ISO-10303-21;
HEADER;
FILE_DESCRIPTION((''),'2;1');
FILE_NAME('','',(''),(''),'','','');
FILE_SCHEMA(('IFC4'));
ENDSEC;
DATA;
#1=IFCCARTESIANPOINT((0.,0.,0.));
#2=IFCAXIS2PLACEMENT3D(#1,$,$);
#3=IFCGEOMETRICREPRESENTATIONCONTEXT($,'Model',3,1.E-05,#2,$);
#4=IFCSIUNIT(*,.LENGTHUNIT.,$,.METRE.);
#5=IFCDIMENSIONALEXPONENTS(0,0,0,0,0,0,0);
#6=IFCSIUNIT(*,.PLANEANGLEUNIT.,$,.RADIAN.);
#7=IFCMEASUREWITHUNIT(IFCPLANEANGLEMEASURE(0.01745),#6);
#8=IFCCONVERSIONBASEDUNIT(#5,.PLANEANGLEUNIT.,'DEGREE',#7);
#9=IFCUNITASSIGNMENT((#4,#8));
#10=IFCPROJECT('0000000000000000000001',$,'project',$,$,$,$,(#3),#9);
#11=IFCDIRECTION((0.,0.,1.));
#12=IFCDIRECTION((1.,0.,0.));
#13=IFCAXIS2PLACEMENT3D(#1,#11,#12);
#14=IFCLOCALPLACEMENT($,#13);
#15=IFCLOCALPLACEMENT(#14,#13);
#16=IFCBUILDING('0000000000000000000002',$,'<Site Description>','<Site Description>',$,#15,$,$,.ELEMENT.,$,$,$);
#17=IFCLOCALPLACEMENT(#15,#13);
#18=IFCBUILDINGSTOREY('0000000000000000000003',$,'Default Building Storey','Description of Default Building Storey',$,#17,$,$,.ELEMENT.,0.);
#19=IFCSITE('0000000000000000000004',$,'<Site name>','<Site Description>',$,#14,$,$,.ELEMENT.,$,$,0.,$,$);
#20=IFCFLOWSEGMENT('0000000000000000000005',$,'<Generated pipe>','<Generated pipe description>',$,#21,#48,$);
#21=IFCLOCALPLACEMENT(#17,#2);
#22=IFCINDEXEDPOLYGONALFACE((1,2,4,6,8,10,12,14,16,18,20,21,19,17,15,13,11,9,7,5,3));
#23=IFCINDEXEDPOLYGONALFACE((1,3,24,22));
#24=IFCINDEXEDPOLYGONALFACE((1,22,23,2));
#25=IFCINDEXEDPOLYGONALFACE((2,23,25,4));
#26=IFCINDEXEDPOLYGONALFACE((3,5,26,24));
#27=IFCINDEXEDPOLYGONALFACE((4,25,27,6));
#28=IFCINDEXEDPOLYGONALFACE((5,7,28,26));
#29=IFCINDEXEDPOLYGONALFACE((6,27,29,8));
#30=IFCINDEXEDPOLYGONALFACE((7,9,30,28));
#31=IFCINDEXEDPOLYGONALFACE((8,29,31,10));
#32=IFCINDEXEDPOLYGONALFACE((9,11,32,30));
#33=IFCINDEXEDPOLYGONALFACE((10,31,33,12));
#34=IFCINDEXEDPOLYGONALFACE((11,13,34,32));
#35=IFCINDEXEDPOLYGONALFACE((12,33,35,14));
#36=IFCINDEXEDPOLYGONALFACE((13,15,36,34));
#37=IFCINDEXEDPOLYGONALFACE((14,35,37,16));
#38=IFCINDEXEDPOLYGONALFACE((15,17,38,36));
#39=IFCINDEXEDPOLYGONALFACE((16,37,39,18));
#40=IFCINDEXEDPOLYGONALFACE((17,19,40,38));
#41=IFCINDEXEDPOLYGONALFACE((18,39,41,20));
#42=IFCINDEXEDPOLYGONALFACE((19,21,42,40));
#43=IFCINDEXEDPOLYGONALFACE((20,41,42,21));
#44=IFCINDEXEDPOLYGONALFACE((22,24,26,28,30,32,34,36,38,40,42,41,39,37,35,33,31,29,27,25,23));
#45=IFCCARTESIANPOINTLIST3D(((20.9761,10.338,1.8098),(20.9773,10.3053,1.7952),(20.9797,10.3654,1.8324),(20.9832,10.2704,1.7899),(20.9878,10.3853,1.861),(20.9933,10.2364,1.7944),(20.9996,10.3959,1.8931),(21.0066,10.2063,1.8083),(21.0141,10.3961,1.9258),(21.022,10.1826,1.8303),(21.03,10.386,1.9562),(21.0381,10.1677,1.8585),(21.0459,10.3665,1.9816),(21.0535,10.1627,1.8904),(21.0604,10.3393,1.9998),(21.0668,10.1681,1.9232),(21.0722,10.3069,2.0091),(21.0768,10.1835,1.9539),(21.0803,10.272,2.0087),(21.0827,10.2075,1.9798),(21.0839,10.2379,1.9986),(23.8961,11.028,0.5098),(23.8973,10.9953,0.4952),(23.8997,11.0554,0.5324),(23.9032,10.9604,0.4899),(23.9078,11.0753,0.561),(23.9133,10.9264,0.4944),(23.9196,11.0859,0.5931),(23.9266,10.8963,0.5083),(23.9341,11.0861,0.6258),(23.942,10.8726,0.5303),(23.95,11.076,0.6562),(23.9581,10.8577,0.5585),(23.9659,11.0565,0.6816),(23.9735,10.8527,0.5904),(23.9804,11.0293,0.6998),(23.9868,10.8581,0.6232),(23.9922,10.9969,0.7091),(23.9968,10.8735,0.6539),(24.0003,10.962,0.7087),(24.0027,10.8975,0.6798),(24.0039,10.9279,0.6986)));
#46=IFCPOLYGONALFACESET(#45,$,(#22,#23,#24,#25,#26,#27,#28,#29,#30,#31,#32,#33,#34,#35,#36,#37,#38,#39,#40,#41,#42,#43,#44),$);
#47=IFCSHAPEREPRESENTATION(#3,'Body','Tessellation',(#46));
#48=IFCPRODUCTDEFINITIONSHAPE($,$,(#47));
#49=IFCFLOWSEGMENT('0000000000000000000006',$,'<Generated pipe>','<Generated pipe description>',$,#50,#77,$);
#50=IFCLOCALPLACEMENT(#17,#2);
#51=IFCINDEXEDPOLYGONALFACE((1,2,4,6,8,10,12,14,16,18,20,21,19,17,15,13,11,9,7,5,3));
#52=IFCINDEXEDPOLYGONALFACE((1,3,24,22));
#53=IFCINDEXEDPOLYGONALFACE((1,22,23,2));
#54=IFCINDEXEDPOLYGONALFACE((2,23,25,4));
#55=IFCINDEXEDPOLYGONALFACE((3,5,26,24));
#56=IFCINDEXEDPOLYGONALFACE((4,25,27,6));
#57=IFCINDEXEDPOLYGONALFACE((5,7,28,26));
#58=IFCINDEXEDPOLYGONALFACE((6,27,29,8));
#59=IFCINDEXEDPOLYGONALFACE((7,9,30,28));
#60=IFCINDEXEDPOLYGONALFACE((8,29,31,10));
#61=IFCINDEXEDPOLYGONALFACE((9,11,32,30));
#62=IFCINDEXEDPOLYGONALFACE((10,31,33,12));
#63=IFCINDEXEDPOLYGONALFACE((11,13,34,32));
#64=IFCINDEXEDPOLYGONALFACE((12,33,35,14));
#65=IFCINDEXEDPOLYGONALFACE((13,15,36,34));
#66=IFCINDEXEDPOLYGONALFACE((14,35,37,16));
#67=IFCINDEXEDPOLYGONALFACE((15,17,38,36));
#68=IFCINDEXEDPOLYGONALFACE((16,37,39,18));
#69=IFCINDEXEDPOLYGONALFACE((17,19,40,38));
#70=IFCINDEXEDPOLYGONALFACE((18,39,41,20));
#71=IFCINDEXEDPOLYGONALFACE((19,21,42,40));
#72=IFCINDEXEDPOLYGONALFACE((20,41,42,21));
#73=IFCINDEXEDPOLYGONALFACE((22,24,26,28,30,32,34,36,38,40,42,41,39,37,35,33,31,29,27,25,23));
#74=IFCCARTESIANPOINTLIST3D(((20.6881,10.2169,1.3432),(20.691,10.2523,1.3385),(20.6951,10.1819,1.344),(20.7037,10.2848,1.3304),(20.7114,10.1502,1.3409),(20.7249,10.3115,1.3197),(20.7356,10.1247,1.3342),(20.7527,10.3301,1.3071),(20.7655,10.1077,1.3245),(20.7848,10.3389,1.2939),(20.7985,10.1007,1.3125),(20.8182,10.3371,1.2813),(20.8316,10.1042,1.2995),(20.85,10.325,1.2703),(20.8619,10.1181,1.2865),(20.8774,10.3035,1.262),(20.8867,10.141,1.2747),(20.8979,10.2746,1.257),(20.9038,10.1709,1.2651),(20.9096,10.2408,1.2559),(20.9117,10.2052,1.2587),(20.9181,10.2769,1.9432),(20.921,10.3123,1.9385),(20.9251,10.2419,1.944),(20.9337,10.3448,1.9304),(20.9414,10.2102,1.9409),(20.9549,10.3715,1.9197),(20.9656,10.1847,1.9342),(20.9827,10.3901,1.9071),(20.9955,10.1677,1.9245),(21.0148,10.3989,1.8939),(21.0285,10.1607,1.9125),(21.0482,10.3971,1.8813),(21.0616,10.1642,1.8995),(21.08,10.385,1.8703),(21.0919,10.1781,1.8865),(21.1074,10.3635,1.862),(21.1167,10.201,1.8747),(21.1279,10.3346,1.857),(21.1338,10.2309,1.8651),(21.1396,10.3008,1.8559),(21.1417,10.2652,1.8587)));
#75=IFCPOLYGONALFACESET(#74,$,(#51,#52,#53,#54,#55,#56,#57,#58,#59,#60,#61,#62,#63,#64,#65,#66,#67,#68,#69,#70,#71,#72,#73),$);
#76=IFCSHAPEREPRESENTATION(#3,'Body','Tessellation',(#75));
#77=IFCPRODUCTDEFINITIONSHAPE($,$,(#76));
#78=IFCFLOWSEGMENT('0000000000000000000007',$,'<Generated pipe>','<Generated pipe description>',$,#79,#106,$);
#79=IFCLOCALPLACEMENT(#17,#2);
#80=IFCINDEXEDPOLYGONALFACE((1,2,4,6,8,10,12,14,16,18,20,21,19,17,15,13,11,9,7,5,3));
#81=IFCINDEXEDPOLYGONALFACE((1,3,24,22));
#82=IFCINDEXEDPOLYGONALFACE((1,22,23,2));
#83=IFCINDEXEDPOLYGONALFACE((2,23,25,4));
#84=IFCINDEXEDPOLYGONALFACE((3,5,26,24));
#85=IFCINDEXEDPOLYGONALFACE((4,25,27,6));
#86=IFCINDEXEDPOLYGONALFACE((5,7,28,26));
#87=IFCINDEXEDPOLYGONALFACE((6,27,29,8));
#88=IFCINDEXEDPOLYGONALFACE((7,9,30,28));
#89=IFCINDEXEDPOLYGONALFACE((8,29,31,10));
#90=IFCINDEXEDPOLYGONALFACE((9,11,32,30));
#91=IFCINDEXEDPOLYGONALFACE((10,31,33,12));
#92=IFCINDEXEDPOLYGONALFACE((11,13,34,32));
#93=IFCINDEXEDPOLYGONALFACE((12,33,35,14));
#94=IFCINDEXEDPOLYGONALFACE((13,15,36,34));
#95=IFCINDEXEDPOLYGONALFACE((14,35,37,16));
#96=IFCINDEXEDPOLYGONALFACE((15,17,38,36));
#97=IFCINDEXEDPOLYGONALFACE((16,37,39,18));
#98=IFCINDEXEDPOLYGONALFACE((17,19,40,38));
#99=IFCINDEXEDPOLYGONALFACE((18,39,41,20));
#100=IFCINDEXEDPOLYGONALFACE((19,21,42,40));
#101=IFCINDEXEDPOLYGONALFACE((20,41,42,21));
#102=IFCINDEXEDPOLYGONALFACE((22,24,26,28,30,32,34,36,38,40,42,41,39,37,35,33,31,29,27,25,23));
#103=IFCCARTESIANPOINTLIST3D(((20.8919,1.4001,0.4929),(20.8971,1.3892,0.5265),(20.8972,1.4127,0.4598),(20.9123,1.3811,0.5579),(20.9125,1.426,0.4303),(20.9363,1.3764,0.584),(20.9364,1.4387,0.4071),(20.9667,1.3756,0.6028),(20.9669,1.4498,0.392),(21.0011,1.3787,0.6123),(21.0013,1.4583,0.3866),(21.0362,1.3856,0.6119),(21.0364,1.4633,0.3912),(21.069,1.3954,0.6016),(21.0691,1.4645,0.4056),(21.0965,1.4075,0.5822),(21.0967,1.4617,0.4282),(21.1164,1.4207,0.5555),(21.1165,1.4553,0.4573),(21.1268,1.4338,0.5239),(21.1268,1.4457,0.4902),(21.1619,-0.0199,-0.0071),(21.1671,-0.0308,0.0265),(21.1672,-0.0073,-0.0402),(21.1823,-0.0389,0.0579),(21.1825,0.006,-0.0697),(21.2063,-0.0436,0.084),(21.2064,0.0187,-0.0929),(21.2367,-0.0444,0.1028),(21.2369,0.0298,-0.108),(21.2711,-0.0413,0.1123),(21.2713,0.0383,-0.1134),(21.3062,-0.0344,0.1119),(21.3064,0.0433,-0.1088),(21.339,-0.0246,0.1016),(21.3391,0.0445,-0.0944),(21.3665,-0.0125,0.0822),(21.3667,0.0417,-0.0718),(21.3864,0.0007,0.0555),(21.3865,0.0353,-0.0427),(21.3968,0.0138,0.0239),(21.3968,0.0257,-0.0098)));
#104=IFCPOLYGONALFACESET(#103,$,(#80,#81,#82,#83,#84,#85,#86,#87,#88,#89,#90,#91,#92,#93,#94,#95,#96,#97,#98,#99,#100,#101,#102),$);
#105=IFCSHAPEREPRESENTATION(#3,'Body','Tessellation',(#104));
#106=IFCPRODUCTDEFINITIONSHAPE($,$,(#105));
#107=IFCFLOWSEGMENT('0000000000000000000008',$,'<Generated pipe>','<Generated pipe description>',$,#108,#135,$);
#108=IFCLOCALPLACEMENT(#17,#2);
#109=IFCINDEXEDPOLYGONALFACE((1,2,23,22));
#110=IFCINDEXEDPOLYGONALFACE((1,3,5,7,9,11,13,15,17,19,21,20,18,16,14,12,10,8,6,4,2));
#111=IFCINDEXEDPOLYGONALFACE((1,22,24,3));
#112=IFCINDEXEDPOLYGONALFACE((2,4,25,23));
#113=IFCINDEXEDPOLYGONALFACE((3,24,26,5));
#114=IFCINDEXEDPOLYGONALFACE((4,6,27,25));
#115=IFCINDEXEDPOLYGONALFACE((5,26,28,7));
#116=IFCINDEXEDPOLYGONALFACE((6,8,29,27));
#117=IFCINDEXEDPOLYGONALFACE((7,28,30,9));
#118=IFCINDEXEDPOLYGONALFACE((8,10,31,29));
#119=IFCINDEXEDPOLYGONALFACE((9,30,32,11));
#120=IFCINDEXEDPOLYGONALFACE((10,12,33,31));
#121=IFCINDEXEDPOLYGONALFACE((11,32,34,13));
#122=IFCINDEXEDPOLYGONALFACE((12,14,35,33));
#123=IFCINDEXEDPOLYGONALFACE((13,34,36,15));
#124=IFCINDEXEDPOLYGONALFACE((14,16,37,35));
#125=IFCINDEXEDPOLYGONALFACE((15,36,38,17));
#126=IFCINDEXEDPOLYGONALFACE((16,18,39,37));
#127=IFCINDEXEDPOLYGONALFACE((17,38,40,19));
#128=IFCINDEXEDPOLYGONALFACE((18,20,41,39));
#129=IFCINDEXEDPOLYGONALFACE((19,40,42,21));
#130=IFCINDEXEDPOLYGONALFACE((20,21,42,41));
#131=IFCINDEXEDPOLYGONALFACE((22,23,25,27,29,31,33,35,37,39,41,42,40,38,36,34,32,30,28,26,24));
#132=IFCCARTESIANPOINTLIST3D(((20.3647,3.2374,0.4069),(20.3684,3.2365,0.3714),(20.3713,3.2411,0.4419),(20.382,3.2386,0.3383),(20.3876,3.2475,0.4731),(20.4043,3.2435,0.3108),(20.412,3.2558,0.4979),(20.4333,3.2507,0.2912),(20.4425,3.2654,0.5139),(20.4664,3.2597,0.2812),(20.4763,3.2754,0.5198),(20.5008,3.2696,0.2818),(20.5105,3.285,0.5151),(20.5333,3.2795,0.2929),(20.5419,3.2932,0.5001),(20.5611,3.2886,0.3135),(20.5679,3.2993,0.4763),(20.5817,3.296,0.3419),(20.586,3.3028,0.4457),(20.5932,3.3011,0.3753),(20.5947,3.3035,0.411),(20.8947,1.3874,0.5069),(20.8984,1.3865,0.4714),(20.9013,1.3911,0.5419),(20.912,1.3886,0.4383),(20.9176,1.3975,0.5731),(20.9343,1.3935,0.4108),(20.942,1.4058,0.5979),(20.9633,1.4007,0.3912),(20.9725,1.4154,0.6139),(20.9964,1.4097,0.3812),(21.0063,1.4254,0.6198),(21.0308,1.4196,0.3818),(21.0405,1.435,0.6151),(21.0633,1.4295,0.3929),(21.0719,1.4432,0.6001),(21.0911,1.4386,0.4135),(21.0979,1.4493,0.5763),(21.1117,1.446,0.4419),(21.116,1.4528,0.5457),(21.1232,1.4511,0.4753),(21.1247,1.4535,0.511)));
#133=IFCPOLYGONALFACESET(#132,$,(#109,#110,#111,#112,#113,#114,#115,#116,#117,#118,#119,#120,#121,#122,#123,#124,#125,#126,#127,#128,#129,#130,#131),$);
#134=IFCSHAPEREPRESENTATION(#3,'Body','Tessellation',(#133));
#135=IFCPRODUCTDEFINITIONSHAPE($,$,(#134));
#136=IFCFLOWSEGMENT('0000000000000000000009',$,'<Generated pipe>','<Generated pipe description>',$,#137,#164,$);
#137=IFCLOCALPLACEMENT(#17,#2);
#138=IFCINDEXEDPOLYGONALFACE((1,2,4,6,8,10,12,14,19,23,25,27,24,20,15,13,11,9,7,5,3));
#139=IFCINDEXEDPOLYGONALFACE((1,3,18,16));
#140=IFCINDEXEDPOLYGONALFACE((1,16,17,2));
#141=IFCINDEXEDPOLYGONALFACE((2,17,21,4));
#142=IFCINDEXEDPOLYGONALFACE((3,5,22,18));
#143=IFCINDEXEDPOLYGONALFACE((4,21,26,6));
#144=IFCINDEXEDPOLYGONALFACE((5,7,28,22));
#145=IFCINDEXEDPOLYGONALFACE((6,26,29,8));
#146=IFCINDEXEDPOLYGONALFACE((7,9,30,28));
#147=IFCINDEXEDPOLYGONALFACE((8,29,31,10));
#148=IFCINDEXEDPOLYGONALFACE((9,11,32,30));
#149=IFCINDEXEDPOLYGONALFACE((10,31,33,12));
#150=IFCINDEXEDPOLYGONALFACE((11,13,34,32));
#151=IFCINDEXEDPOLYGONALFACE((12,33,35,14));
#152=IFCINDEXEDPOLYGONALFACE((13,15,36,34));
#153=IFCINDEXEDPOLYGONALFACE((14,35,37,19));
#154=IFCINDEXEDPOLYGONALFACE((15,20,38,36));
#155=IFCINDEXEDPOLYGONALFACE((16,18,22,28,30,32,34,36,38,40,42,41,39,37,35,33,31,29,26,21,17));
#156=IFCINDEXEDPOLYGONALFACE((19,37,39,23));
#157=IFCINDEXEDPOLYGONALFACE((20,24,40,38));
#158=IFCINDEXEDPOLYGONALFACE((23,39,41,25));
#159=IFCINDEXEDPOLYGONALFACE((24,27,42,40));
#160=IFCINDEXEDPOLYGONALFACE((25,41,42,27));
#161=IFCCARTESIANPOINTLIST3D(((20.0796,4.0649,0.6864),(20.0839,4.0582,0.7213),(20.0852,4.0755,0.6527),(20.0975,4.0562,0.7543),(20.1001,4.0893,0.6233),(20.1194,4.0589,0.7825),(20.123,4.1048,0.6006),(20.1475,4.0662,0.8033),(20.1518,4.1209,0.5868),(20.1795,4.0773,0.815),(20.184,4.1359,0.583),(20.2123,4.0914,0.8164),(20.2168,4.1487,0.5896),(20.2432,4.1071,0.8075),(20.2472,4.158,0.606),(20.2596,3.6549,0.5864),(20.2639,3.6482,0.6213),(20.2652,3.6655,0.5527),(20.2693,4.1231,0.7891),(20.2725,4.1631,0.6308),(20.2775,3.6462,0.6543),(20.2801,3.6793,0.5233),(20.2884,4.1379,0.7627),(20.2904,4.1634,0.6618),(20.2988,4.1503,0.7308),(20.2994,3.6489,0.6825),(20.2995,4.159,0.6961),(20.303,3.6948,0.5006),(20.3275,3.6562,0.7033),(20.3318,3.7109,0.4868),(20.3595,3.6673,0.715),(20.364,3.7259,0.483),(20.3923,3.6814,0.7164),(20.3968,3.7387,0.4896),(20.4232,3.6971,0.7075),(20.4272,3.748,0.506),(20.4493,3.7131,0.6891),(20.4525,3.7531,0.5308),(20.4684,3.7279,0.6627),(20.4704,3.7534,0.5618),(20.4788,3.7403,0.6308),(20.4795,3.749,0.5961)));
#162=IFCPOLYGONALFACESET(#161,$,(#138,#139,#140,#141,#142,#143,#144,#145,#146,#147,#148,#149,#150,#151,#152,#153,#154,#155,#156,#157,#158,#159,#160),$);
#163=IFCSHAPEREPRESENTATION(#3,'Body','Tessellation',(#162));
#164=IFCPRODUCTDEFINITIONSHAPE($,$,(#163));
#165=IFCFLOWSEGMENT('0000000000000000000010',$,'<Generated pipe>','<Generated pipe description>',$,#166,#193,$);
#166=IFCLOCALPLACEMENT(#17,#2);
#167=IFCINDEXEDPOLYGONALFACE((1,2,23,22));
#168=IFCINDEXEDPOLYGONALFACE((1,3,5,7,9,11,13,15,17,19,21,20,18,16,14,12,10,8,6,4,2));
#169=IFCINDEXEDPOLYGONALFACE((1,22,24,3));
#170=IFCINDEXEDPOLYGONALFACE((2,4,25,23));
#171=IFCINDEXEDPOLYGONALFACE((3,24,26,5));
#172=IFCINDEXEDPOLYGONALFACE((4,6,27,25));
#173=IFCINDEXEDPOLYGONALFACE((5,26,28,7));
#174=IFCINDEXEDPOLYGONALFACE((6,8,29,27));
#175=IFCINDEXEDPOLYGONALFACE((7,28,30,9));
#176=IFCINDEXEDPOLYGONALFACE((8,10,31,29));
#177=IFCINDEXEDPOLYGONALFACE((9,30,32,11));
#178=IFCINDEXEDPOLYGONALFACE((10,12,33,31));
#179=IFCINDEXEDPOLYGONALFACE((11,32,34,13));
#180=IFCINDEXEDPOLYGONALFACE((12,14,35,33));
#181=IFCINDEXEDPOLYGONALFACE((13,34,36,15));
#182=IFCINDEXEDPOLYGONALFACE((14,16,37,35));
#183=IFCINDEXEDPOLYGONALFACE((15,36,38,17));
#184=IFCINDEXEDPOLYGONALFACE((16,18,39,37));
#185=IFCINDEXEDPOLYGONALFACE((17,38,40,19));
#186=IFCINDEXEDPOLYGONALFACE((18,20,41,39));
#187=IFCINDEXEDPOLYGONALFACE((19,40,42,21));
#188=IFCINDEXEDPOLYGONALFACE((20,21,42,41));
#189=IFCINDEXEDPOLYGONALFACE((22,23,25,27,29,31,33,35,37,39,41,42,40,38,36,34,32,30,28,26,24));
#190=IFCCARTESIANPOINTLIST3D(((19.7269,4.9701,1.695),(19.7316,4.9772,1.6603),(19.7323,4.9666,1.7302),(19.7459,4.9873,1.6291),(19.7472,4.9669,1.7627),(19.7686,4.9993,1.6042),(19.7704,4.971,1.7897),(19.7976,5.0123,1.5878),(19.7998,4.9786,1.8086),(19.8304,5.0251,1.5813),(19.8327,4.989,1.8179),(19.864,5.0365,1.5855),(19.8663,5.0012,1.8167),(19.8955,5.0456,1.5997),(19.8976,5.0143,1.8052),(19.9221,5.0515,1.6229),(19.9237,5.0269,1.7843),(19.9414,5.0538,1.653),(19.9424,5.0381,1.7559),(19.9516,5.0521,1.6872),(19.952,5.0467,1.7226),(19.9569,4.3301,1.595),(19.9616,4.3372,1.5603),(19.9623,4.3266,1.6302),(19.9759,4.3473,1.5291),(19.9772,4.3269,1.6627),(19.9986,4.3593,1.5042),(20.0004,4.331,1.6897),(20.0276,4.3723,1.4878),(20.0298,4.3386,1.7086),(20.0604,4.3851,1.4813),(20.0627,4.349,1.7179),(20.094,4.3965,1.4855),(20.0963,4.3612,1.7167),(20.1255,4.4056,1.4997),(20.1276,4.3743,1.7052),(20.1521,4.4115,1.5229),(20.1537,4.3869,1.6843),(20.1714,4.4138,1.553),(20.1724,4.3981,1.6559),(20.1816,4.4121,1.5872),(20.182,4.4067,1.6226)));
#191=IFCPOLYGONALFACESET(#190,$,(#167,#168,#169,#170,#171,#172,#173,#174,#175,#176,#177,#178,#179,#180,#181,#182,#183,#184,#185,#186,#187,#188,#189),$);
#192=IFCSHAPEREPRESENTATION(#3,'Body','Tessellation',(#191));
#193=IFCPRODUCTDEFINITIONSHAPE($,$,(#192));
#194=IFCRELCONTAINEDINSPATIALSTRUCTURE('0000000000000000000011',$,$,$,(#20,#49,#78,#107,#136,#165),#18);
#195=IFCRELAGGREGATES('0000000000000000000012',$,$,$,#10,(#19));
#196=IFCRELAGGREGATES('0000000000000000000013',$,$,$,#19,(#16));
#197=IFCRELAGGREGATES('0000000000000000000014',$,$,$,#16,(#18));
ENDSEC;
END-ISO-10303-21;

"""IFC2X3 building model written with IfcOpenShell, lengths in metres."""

from ifc_helpers import new_model, entity, si_unit, converted_unit, frame, origin, origin_with_axes, origin_2d_with_axis, place, context, project, spatial, circle, extrude, element, save


model = new_model("IFC2X3")

# Units and contexts
model_context = context("Model", 3, precision=1e-05, world=origin())
ifc_project = project(units=[si_unit("LENGTHUNIT", "METRE"), converted_unit("PLANEANGLEUNIT", "DEGREE", entity("IfcPlaneAngleMeasure", 0.01745), si_unit("PLANEANGLEUNIT", "RADIAN"), dimensions=[0, 0, 0, 0, 0, 0, 0])], contexts=[model_context])

# Site, building, storey
site_placement = place(None, origin_with_axes())
site = spatial("IfcSite", under=ifc_project, at=site_placement, Name="<Site name>", Description="<Site Description>", CompositionType="ELEMENT", RefElevation=0.0)
building_placement = place(site_placement, origin_with_axes())
building = spatial("IfcBuilding", under=site, at=building_placement, Name="<Site Description>", Description="<Site Description>", CompositionType="ELEMENT")
storey_placement = place(building_placement, origin_with_axes())
storey = spatial("IfcBuildingStorey", under=building, at=storey_placement, Name="Default Building Storey", Description="Description of Default Building Storey", CompositionType="ELEMENT", Elevation=0.0)

# Flow segments
flow_segment_1_placement = place(storey_placement, frame((23.95, 10.97, 0.6), z_axis=(-0.892983, -0.211013, 0.397561), x_axis=(0.253344, 0.49443, 0.831478)))
element("IfcFlowSegment", 1, at=flow_segment_1_placement, inside=storey, Name="<Generated pipe>", Description="<Generated pipe description>", context=model_context, shape_type="SweptSolid", body=[
    extrude(circle(Radius=0.12, at=origin_2d_with_axis()), origin_with_axes(), (0.0, 0.0, 1.0), 3.2699),
])
flow_segment_2_placement = place(storey_placement, frame((21.03, 10.28, 1.9), z_axis=(-0.356386, -0.09297, -0.929702), x_axis=(0.41681, 0.874721, -0.247249)))
element("IfcFlowSegment", 2, at=flow_segment_2_placement, inside=storey, Name="<Generated pipe>", Description="<Generated pipe description>", context=model_context, shape_type="SweptSolid", body=[
    extrude(circle(Radius=0.12, at=origin_2d_with_axis()), origin_with_axes(), (0.0, 0.0, 1.0), 0.6454),
])
flow_segment_3_placement = place(storey_placement, frame((21.28, 0.0, 0.0), z_axis=(-0.176531, 0.928422, 0.326909), x_axis=(0.491379, -0.204653, 0.84656)))
element("IfcFlowSegment", 3, at=flow_segment_3_placement, inside=storey, Name="<Generated pipe>", Description="<Generated pipe description>", context=model_context, shape_type="SweptSolid", body=[
    extrude(circle(Radius=0.12, at=origin_2d_with_axis()), origin_with_axes(), (0.0, 0.0, 1.0), 1.5295),
])
flow_segment_4_placement = place(storey_placement, frame((21.01, 1.42, 0.5), z_axis=(-0.275036, 0.960032, -0.051894), x_axis=(0.883333, 0.273635, 0.380587)))
element("IfcFlowSegment", 4, at=flow_segment_4_placement, inside=storey, Name="<Generated pipe>", Description="<Generated pipe description>", context=model_context, shape_type="SweptSolid", body=[
    extrude(circle(Radius=0.12, at=origin_2d_with_axis()), origin_with_axes(), (0.0, 0.0, 1.0), 1.927),
])
flow_segment_5_placement = place(storey_placement, frame((20.37, 3.7, 0.6), z_axis=(-0.392325, 0.89363, 0.217959), x_axis=(0.820272, 0.232678, 0.522508)))
element("IfcFlowSegment", 5, at=flow_segment_5_placement, inside=storey, Name="<Generated pipe>", Description="<Generated pipe description>", context=model_context, shape_type="SweptSolid", body=[
    extrude(circle(Radius=0.12, at=origin_2d_with_axis()), origin_with_axes(), (0.0, 0.0, 1.0), 0.4588),
])
flow_segment_6_placement = place(storey_placement, frame((20.07, 4.37, 1.6), z_axis=(-0.334601, 0.931063, 0.145479), x_axis=(0.933261, 0.305997, 0.188121)))
element("IfcFlowSegment", 6, at=flow_segment_6_placement, inside=storey, Name="<Generated pipe>", Description="<Generated pipe description>", context=model_context, shape_type="SweptSolid", body=[
    extrude(circle(Radius=0.12, at=origin_2d_with_axis()), origin_with_axes(), (0.0, 0.0, 1.0), 0.6874),
])

save(model, "model.ifc")
